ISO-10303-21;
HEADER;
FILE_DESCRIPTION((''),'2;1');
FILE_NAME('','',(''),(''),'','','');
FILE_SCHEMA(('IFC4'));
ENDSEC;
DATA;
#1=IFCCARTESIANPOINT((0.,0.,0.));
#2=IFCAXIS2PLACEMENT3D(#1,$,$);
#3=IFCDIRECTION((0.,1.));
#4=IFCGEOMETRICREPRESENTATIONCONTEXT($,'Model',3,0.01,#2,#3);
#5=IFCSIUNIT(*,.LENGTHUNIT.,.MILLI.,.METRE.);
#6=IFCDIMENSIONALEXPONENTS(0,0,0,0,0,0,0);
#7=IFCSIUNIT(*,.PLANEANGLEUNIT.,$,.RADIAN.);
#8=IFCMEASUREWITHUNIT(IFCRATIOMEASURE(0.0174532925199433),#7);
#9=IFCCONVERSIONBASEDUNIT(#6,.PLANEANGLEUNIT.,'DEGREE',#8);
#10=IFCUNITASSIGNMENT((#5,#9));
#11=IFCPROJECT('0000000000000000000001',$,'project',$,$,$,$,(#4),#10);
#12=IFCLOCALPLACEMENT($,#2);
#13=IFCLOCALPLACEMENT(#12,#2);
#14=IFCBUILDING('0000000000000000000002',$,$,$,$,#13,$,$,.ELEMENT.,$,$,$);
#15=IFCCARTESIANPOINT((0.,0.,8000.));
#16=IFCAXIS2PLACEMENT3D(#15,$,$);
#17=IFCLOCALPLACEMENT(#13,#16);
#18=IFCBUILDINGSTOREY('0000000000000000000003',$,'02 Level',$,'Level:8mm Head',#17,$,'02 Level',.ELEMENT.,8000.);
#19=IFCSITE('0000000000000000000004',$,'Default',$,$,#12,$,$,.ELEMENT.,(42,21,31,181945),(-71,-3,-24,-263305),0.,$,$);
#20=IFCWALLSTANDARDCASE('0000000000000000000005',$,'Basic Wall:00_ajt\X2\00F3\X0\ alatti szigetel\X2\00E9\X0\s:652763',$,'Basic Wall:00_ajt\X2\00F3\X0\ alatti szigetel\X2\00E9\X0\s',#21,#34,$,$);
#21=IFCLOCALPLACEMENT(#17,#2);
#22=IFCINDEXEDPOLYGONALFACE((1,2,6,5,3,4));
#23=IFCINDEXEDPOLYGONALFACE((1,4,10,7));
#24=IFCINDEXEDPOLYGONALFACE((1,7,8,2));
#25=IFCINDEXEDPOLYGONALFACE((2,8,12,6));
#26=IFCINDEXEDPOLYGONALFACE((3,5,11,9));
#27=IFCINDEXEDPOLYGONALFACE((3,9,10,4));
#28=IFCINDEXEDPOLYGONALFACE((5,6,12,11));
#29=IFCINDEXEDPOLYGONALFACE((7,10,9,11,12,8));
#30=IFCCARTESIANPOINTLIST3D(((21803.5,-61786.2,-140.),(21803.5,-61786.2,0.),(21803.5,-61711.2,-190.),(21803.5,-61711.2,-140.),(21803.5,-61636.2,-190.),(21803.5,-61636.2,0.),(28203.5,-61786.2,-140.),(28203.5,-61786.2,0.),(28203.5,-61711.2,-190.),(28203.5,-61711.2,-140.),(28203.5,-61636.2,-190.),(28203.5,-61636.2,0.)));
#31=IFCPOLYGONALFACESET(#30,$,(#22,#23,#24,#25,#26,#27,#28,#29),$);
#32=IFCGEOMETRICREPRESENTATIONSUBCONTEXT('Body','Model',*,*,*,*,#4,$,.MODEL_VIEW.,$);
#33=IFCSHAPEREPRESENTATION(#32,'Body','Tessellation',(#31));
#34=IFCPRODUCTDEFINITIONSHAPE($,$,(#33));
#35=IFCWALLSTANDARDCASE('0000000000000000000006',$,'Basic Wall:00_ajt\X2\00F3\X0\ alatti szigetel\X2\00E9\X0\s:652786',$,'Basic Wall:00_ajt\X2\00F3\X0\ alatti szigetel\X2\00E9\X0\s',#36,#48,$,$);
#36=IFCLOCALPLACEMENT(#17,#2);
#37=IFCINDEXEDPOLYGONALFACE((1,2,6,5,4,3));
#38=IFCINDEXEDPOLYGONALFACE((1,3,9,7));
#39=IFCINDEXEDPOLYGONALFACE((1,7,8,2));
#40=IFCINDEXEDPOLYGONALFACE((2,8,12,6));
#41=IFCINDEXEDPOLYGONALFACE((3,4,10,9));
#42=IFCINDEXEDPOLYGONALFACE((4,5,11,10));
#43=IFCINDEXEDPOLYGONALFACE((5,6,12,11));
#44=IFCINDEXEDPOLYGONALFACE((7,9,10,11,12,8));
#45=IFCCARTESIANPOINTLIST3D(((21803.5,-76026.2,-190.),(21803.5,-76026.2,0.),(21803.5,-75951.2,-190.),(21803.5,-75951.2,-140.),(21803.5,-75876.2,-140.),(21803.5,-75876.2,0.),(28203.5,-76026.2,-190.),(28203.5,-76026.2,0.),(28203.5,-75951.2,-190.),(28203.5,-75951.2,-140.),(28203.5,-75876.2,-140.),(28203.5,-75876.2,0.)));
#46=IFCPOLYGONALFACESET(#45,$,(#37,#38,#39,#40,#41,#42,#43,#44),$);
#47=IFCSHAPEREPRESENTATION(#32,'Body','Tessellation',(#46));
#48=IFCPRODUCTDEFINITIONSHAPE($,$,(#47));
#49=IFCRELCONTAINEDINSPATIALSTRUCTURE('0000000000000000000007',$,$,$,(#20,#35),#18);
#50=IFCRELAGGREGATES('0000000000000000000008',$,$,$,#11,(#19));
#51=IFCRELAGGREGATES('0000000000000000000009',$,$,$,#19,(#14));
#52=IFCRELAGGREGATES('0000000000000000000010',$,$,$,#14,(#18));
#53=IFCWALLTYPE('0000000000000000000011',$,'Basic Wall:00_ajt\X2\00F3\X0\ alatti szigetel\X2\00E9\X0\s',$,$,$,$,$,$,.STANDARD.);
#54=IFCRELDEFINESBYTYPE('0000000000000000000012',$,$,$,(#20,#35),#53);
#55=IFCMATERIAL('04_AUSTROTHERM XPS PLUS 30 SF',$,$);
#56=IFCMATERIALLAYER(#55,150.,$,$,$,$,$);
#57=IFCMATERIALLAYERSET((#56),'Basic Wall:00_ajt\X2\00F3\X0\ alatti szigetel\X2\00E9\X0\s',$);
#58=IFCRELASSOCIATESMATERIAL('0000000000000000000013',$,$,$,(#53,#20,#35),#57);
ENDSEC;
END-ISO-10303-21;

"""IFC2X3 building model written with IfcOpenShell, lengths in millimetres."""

from ifc_helpers import new_model, entity, si_unit, converted_unit, direction, frame, frame_2d, origin, place, context, subcontext, project, spatial, polyline, rectangle, extrude, clip, bounded_halfspace, material, layer, layer_set, layer_usage, type_object, element, save


model = new_model("IFC2X3")

# Units and contexts
model_context = context("Model", 3, precision=0.01, world=origin(), true_north=direction((0.0, 1.0)))
body_context = subcontext(model_context, "Body", "Model", "MODEL_VIEW")
ifc_project = project(units=[si_unit("LENGTHUNIT", "METRE", prefix="MILLI"), converted_unit("PLANEANGLEUNIT", "DEGREE", entity("IfcRatioMeasure", 0.0174532925199433), si_unit("PLANEANGLEUNIT", "RADIAN"), dimensions=[0, 0, 0, 0, 0, 0, 0])], contexts=[model_context])

# Site, building, storey
site_placement = place(None, origin())
site = spatial("IfcSite", under=ifc_project, at=site_placement, Name="Default", CompositionType="ELEMENT", RefLatitude=(42, 21, 31, 181945), RefLongitude=(-71, -3, -24, -263305), RefElevation=0.0)
building_placement = place(site_placement, origin())
building = spatial("IfcBuilding", under=site, at=building_placement, CompositionType="ELEMENT")
storey_placement = place(building_placement, frame((0.0, 0.0, 8000.0)))
storey = spatial("IfcBuildingStorey", under=building, at=storey_placement, Name="02 Level", ObjectType="Level:8mm Head", LongName="02 Level", CompositionType="ELEMENT", Elevation=8000.0)

# Walls
ifc_material = material(Name="04_AUSTROTHERM XPS PLUS 30 SF")
ifc_layer = layer(ifc_material, 150.0)
ifc_layer_set = layer_set([ifc_layer], Name="Basic Wall:00_ajtó alatti szigetelés")
ifc_layer_usage_1 = layer_usage(ifc_layer_set, "AXIS2", "POSITIVE", -75.0)
wall_type = type_object("IfcWallType", Name="Basic Wall:00_ajtó alatti szigetelés", PredefinedType="STANDARD", material=ifc_layer_set)
wall_1_placement = place(storey_placement, frame((28203.5, -61711.2, -190.0), z_axis=(0.0, 0.0, 1.0), x_axis=(-1.0, 0.0, 0.0)))
element("IfcWallStandardCase", 1, at=wall_1_placement, inside=storey, type_object=wall_type, material=ifc_layer_usage_1, Name="Basic Wall:00_ajtó alatti szigetelés:652763", ObjectType="Basic Wall:00_ajtó alatti szigetelés", context=body_context, shape_type="Clipping", body=[
    clip(clip(extrude(rectangle(XDim=6400.0, YDim=150.0, at=frame_2d((3200.0, 0.0), x_axis=(-1.0, 0.0))), origin(), (0.0, 0.0, 1.0), 190.0), bounded_halfspace(frame((6400.0, 0.0, 50.0)), True, frame((6400.0, 0.0, 50.0)), polyline([(0.0, 0.0), (0.0, 75.0), (-6400.0, 75.0), (-6400.0, 0.0), (0.0, 0.0)]))), bounded_halfspace(frame((0.0, 0.0, 50.0), z_axis=(0.0, -1.0, 0.0), x_axis=(0.0, 0.0, 1.0)), True, frame((0.0, 0.0, 50.0), z_axis=(0.0, -1.0, 0.0), x_axis=(0.0, 0.0, 1.0)), polyline([(0.0, 0.0), (-50.0, 0.0), (-50.0, -6400.0), (0.0, -6400.0), (0.0, 0.0)]))),
])
ifc_layer_usage_2 = layer_usage(ifc_layer_set, "AXIS2", "NEGATIVE", 75.0)
wall_2_placement = place(storey_placement, frame((28203.5, -75951.2, -190.0), z_axis=(0.0, 0.0, 1.0), x_axis=(-1.0, 0.0, 0.0)))
element("IfcWallStandardCase", 2, at=wall_2_placement, inside=storey, type_object=wall_type, material=ifc_layer_usage_2, Name="Basic Wall:00_ajtó alatti szigetelés:652786", ObjectType="Basic Wall:00_ajtó alatti szigetelés", context=body_context, shape_type="Clipping", body=[
    clip(clip(extrude(rectangle(XDim=6400.0, YDim=150.0, at=frame_2d((3200.0, 0.0), x_axis=(-1.0, 0.0))), origin(), (0.0, 0.0, 1.0), 190.0), bounded_halfspace(frame((0.0, 0.0, 50.0)), True, frame((0.0, 0.0, 50.0)), polyline([(0.0, 0.0), (0.0, -75.0), (6400.0, -75.0), (6400.0, 0.0), (0.0, 0.0)]))), bounded_halfspace(frame((6400.0, 0.0, 50.0), z_axis=(0.0, 1.0, 0.0), x_axis=(0.0, 0.0, 1.0)), True, frame((6400.0, 0.0, 50.0), z_axis=(0.0, 1.0, 0.0), x_axis=(0.0, 0.0, 1.0)), polyline([(0.0, 0.0), (-50.0, 0.0), (-50.0, -6400.0), (0.0, -6400.0), (0.0, 0.0)]))),
])

save(model, "model.ifc")
